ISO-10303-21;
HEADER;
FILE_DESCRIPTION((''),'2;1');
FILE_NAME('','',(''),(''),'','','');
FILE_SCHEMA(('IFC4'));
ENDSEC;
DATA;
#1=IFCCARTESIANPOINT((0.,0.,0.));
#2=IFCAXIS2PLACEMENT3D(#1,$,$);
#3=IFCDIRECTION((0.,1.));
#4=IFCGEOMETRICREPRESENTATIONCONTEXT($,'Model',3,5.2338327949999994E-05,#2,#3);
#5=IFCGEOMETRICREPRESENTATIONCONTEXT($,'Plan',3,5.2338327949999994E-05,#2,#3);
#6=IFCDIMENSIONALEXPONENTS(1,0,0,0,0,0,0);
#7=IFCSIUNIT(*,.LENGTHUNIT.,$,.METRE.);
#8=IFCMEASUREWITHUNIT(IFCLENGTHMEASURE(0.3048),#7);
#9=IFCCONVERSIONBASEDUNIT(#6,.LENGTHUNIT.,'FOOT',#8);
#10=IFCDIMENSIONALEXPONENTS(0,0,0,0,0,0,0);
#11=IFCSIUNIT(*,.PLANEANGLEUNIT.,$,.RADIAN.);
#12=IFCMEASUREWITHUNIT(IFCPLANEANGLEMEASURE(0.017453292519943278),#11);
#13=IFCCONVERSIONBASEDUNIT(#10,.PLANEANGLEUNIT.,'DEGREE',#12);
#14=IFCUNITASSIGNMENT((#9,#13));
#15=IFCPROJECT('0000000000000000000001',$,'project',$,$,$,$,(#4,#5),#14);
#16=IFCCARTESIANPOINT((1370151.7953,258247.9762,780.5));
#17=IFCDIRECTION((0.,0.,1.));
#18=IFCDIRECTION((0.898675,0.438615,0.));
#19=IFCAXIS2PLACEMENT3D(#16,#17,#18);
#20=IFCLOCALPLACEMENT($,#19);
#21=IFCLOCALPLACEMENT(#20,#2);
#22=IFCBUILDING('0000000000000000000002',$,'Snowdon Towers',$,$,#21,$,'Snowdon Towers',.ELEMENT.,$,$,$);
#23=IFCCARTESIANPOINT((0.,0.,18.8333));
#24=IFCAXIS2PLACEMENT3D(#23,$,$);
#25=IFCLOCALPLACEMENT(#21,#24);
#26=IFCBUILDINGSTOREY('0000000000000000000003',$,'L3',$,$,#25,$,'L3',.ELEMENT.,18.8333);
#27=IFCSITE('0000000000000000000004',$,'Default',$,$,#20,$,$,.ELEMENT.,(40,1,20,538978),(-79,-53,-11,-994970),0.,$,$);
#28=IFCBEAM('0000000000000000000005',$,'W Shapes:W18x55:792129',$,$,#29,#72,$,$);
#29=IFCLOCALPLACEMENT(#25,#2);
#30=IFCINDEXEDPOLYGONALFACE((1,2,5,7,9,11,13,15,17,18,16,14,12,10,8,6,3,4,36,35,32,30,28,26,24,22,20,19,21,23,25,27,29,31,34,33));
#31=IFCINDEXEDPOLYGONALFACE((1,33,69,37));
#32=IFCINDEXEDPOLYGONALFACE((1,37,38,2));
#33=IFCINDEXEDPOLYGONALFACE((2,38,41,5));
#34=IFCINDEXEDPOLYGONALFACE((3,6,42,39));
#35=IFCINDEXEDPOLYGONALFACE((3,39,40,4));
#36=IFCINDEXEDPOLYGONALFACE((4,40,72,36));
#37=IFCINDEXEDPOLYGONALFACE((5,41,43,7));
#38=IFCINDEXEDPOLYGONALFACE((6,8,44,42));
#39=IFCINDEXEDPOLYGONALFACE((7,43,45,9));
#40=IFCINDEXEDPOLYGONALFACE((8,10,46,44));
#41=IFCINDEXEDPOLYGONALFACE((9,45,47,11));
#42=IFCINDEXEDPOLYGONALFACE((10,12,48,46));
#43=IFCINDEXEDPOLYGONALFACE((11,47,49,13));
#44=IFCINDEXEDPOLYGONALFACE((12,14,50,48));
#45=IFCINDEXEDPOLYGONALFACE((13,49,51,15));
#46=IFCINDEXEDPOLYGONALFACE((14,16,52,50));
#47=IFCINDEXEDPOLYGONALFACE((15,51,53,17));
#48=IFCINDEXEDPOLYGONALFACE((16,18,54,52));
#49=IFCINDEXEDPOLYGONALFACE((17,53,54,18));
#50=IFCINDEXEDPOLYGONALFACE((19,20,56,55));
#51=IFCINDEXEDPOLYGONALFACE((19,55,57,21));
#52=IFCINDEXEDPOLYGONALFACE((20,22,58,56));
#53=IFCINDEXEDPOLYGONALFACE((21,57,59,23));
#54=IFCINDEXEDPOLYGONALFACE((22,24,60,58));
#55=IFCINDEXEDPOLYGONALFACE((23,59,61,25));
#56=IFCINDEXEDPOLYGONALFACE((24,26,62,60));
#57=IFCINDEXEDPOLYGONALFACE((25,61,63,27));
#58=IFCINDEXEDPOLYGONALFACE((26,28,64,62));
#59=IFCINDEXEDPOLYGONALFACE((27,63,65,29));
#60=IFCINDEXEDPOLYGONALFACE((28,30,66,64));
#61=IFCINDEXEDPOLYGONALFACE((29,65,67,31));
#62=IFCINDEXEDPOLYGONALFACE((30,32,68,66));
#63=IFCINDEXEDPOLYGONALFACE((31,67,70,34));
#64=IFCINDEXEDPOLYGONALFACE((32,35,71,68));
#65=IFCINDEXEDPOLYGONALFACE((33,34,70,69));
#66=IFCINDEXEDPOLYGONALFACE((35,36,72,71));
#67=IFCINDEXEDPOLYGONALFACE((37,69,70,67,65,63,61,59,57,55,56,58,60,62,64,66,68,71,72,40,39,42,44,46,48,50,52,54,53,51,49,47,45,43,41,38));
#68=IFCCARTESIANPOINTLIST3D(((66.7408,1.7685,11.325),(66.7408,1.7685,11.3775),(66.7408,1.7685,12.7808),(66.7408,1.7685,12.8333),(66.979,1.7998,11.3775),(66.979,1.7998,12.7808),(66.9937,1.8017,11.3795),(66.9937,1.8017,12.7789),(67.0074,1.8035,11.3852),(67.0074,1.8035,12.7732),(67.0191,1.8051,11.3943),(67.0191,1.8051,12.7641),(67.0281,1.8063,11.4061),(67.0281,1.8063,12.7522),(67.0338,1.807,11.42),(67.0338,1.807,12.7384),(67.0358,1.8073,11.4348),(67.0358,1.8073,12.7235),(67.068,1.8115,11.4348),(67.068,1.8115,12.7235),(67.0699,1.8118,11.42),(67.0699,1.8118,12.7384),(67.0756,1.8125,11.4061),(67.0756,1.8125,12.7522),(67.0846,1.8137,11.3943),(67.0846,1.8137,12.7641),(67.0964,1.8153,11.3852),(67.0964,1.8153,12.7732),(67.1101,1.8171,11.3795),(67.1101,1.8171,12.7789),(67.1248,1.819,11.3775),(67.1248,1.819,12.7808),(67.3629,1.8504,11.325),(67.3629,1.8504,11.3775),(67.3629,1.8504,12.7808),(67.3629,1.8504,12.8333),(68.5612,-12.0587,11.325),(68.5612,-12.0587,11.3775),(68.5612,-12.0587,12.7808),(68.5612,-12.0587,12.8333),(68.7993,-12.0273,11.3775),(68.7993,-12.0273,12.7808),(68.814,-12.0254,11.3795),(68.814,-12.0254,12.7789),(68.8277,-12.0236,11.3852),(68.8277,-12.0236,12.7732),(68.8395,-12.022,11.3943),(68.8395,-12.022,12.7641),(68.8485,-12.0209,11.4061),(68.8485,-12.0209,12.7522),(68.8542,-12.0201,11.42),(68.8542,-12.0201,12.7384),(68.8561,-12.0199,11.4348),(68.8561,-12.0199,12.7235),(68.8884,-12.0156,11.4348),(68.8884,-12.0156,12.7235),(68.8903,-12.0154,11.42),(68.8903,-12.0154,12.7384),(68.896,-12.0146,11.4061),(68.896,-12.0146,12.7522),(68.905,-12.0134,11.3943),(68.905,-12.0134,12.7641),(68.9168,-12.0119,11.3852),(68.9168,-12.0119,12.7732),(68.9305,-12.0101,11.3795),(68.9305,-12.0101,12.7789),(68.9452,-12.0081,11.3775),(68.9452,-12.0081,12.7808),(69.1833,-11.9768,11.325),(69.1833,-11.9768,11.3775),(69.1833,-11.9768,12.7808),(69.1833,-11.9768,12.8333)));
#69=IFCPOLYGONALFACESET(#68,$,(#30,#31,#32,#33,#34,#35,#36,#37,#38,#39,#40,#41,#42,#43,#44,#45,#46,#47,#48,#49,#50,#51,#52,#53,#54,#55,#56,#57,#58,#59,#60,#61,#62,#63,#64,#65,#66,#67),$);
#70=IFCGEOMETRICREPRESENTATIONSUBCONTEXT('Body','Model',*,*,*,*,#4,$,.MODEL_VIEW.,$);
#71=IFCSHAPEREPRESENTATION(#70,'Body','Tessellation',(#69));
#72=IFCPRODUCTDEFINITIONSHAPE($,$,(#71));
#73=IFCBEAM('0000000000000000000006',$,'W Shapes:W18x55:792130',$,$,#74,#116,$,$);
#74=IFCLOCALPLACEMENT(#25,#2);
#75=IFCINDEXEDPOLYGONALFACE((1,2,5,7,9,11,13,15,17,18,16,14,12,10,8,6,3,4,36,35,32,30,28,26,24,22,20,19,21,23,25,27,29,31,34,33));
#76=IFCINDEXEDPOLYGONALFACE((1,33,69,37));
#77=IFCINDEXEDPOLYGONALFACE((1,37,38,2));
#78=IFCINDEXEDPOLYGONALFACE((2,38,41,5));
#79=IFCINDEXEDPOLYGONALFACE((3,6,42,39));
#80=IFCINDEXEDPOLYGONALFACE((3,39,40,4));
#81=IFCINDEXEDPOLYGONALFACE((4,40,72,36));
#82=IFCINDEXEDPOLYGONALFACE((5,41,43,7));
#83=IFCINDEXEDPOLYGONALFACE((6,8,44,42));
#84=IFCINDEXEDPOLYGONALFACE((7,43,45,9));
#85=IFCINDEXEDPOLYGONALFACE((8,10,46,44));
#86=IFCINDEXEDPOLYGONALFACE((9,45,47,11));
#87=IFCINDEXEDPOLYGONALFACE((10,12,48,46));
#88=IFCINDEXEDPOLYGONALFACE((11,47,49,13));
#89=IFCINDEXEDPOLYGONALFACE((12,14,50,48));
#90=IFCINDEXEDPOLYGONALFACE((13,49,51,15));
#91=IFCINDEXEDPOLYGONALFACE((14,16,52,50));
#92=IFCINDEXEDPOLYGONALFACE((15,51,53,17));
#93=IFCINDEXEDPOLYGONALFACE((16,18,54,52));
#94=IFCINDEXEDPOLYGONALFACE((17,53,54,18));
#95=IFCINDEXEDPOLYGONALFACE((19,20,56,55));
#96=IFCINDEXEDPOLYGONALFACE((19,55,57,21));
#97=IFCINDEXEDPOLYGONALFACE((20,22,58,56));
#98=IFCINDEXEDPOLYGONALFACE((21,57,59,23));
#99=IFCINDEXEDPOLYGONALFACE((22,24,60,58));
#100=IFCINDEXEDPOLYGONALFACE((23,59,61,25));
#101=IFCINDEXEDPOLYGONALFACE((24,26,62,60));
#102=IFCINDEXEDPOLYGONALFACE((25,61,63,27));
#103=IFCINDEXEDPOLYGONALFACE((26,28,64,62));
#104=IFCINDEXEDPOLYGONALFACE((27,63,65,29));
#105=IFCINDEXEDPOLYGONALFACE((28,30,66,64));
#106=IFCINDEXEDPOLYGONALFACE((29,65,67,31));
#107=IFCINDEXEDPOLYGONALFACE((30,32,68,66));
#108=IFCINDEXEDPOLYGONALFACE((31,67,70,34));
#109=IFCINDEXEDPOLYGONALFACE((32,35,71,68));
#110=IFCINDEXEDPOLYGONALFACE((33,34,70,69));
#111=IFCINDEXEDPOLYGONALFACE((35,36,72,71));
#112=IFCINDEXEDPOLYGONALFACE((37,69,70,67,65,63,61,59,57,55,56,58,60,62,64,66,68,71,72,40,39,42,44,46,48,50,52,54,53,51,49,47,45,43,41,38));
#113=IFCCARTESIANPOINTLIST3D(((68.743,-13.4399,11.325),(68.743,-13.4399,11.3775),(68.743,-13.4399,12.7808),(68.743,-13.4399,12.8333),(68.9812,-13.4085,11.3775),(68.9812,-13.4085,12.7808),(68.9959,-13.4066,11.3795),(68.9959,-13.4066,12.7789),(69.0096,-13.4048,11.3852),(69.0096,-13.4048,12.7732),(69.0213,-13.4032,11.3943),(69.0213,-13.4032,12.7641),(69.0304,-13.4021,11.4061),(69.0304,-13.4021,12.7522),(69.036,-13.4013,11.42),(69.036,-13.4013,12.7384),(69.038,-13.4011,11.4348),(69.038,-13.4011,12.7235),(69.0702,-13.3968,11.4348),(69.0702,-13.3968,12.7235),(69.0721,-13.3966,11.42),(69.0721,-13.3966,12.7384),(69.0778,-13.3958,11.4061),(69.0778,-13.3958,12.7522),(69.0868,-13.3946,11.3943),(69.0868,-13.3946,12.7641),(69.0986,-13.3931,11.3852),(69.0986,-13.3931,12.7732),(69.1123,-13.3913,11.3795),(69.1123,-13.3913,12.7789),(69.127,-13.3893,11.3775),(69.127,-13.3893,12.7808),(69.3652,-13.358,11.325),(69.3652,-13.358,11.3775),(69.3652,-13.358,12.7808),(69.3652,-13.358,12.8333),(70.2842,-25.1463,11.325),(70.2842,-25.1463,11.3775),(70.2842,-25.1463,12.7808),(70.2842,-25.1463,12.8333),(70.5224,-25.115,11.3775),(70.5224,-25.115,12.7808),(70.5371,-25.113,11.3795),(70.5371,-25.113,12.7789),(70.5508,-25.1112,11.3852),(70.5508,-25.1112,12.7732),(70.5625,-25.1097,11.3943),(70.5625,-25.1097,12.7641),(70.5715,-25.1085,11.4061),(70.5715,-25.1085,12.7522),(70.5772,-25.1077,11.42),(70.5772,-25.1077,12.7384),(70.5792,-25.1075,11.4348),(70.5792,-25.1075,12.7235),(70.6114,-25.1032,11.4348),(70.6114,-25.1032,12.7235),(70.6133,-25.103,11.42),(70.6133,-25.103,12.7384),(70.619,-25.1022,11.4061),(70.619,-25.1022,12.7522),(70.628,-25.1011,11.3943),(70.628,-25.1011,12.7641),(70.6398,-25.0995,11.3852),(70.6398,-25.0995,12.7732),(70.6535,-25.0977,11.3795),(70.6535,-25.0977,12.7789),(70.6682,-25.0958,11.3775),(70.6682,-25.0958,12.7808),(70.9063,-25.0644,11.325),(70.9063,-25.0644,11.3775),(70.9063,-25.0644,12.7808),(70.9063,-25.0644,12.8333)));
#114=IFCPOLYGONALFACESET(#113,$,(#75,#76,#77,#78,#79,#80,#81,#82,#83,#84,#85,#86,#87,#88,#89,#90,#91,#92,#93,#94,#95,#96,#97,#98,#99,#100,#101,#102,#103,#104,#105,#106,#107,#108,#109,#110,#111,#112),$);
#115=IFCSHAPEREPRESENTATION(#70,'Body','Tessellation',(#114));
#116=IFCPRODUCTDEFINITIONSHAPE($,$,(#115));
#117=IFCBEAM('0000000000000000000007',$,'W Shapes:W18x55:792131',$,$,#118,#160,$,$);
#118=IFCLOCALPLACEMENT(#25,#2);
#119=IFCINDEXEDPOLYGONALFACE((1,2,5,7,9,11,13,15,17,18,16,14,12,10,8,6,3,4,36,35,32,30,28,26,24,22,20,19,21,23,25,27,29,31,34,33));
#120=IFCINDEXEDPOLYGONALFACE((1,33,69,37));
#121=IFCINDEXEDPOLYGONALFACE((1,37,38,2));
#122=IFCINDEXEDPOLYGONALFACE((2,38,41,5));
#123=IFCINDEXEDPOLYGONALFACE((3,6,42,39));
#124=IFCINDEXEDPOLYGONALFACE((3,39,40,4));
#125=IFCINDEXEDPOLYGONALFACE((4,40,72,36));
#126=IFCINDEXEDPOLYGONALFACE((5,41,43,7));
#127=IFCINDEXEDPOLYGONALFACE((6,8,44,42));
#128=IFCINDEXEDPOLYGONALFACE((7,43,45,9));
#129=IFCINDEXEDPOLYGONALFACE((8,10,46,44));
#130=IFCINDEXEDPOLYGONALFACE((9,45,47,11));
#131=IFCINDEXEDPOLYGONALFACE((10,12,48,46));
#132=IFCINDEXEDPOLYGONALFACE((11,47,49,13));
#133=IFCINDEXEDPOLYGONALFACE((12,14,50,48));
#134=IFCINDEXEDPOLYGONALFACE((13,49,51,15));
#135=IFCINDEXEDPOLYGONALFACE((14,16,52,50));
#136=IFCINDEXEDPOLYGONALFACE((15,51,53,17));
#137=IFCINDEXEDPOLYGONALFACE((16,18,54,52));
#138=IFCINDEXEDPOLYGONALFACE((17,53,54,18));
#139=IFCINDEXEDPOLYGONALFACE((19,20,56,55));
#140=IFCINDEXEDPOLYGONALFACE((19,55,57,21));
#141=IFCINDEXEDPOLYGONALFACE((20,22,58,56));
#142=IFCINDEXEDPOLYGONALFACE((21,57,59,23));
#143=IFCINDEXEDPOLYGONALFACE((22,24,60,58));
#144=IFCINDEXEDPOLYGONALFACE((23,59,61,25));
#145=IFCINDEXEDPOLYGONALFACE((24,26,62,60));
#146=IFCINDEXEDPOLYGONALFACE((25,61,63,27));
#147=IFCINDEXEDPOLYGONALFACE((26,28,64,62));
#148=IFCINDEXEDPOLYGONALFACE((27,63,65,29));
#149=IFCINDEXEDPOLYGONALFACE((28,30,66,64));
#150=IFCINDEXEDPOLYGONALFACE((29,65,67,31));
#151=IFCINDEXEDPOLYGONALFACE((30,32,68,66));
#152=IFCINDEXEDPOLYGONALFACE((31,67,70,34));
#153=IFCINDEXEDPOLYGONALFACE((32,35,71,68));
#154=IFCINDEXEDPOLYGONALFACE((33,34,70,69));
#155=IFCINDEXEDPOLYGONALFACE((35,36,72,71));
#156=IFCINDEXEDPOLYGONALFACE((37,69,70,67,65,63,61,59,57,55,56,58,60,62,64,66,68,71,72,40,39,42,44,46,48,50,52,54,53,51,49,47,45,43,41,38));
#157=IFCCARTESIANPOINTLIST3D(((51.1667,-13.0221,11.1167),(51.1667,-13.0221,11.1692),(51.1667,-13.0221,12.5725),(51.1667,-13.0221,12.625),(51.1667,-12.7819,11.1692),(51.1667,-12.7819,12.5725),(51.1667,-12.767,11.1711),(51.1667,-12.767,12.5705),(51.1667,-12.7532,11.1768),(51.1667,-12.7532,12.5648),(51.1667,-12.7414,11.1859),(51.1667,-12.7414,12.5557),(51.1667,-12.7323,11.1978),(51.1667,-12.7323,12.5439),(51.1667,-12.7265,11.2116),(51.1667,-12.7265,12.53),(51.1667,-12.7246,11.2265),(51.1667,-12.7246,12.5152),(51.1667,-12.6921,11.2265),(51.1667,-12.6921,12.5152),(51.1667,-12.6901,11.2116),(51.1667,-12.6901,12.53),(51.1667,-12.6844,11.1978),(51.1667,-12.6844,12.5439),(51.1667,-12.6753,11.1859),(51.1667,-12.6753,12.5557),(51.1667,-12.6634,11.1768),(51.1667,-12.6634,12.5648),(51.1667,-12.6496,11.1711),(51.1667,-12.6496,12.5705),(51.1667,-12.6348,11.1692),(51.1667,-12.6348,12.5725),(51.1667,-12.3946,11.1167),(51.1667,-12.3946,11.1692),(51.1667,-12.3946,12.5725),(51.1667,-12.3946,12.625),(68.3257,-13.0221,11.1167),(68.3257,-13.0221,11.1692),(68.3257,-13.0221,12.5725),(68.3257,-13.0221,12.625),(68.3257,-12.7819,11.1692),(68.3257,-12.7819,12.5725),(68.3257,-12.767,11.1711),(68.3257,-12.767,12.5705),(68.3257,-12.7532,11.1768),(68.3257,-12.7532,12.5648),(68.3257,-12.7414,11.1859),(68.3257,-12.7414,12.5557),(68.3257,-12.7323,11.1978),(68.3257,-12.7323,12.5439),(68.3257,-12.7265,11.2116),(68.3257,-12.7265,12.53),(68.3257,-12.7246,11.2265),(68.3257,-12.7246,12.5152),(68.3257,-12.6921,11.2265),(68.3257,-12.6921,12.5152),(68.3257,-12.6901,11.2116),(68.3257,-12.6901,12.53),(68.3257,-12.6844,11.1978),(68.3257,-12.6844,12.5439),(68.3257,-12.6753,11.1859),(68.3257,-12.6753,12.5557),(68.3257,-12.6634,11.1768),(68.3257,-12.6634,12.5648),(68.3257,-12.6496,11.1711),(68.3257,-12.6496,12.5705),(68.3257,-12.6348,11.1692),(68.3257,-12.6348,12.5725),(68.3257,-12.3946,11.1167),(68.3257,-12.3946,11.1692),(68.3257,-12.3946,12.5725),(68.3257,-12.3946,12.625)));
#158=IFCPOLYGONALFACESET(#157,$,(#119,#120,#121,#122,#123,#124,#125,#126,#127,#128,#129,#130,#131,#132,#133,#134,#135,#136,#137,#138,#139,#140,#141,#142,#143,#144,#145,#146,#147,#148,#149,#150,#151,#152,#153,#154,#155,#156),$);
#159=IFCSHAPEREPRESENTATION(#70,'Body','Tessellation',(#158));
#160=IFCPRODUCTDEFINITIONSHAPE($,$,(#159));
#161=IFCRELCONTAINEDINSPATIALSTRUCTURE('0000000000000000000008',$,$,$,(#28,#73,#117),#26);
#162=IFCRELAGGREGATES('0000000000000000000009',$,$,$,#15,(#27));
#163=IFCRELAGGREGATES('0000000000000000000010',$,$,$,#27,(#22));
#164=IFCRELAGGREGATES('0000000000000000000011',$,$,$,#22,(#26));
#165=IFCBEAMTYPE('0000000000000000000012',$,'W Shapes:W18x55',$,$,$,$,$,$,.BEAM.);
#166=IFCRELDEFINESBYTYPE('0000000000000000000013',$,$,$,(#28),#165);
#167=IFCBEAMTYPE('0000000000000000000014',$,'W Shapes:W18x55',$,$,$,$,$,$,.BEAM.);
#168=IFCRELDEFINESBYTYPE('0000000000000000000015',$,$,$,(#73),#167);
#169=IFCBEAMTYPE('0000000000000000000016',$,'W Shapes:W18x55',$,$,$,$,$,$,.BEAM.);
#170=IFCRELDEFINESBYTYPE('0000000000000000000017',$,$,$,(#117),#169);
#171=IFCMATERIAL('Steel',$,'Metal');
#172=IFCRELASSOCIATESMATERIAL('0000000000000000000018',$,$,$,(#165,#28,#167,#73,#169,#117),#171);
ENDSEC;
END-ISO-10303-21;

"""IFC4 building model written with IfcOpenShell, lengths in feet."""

from ifc_helpers import new_model, entity, si_unit, converted_unit, direction, frame, origin, place, context, subcontext, project, spatial, line, arc, indexed_curve, outline, extrude, source, transform, mapped, material, type_object, type_shapes, element, save


model = new_model("IFC4")

# Units and contexts
model_context = context("Model", 3, precision=5.2338327949999994e-05, world=origin(), true_north=direction((0.0, 1.0)))
plan_context = context("Plan", 3, precision=5.2338327949999994e-05, world=origin(), true_north=direction((0.0, 1.0)))
body_context = subcontext(model_context, "Body", "Model", "MODEL_VIEW")
ifc_project = project(units=[converted_unit("LENGTHUNIT", "FOOT", entity("IfcLengthMeasure", 0.3048), si_unit("LENGTHUNIT", "METRE"), dimensions=[1, 0, 0, 0, 0, 0, 0]), converted_unit("PLANEANGLEUNIT", "DEGREE", entity("IfcPlaneAngleMeasure", 0.017453292519943278), si_unit("PLANEANGLEUNIT", "RADIAN"), dimensions=[0, 0, 0, 0, 0, 0, 0])], contexts=[model_context, plan_context])

# Site, building, storey
site_placement = place(None, frame((1370151.7953, 258247.9762, 780.5), z_axis=(0.0, 0.0, 1.0), x_axis=(0.898675, 0.438615, 0.0)))
site = spatial("IfcSite", under=ifc_project, at=site_placement, Name="Default", CompositionType="ELEMENT", RefLatitude=(40, 1, 20, 538978), RefLongitude=(-79, -53, -11, -994970), RefElevation=0.0)
building_placement = place(site_placement, origin())
building = spatial("IfcBuilding", under=site, at=building_placement, Name="Snowdon Towers", LongName="Snowdon Towers", CompositionType="ELEMENT")
storey_placement = place(building_placement, frame((0.0, 0.0, 18.8333)))
storey = spatial("IfcBuildingStorey", under=building, at=storey_placement, Name="L3", LongName="L3", CompositionType="ELEMENT", Elevation=18.8333)

# Beams
ifc_material_1 = material(Name="Steel", Category="Metal")
beam_type_1 = type_object("IfcBeamType", Name="W Shapes:W18x55", PredefinedType="BEAM", material=ifc_material_1)
shared_shape_1 = source(origin(), body_context, "Body", "SweptSolid", [
    extrude(outline(indexed_curve([(-0.7542, -0.3138), (-0.7017, -0.3138), (-0.7017, -0.0735), (-0.6849, -0.033), (-0.6444, -0.0162), (0.6444, -0.0162), (0.6849, -0.033), (0.7017, -0.0735), (0.7017, -0.3138), (0.7542, -0.3138), (0.7542, 0.3138), (0.7017, 0.3138), (0.7017, 0.0735), (0.6849, 0.033), (0.6444, 0.0163), (-0.6444, 0.0163), (-0.6849, 0.033), (-0.7017, 0.0735), (-0.7017, 0.3137), (-0.7542, 0.3137)], segments=[line(1, 2, 3), arc(3, 4, 5), line(5, 6), arc(6, 7, 8), line(8, 9, 10, 11, 12, 13), arc(13, 14, 15), line(15, 16), arc(16, 17, 18), line(18, 19, 20, 1)], self_intersect=False)), frame((-7.05, 0.0, 0.0), z_axis=(1.0, 0.0, 0.0), x_axis=(0.0, 0.0, -1.0)), (0.0, 0.0, 1.0), 13.9465),
])
type_shapes(beam_type_1, [shared_shape_1])
beam_1_placement = place(storey_placement, frame((67.9721, -5.1803, 12.0792), z_axis=(0.0, 0.0, 1.0), x_axis=(0.130526, -0.991445, 0.0)))
element("IfcBeam", 1, at=beam_1_placement, inside=storey, type_object=beam_type_1, material=ifc_material_1, Name="W Shapes:W18x55:792129", context=body_context, shape_type="MappedRepresentation", body=[
    mapped(shared_shape_1, transform((0.0, 0.0, 0.0), scale=1.0)),
])
beam_type_2 = type_object("IfcBeamType", Name="W Shapes:W18x55", PredefinedType="BEAM", material=ifc_material_1)
shared_shape_2 = source(origin(), body_context, "Body", "SweptSolid", [
    extrude(outline(indexed_curve([(-0.7542, -0.3138), (-0.7017, -0.3138), (-0.7017, -0.0735), (-0.6849, -0.033), (-0.6444, -0.0162), (0.6444, -0.0162), (0.6849, -0.033), (0.7017, -0.0735), (0.7017, -0.3138), (0.7542, -0.3138), (0.7542, 0.3138), (0.7017, 0.3138), (0.7017, 0.0735), (0.6849, 0.033), (0.6444, 0.0163), (-0.6444, 0.0163), (-0.6849, 0.033), (-0.7017, 0.0735), (-0.7017, 0.3137), (-0.7542, 0.3137)], segments=[line(1, 2, 3), arc(3, 4, 5), line(5, 6), arc(6, 7, 8), line(8, 9, 10, 11, 12, 13), arc(13, 14, 15), line(15, 16), arc(16, 17, 18), line(18, 19, 20, 1)], self_intersect=False)), frame((-5.9188, 0.0, 0.0), z_axis=(1.0, 0.0, 0.0), x_axis=(0.0, 0.0, -1.0)), (0.0, 0.0, 1.0), 11.8075),
])
type_shapes(beam_type_2, [shared_shape_2])
beam_2_placement = place(storey_placement, frame((69.8266, -19.2671, 12.0792), z_axis=(0.0, 0.0, 1.0), x_axis=(0.130526, -0.991445, 0.0)))
element("IfcBeam", 2, at=beam_2_placement, inside=storey, type_object=beam_type_2, material=ifc_material_1, Name="W Shapes:W18x55:792130", context=body_context, shape_type="MappedRepresentation", body=[
    mapped(shared_shape_2, transform((0.0, 0.0, 0.0), scale=1.0)),
])
beam_type_3 = type_object("IfcBeamType", Name="W Shapes:W18x55", PredefinedType="BEAM", material=ifc_material_1)
shared_shape_3 = source(origin(), body_context, "Body", "SweptSolid", [
    extrude(outline(indexed_curve([(-0.7542, -0.3138), (-0.7017, -0.3138), (-0.7017, -0.0735), (-0.6849, -0.033), (-0.6444, -0.0162), (0.6444, -0.0162), (0.6849, -0.033), (0.7017, -0.0735), (0.7017, -0.3138), (0.7542, -0.3138), (0.7542, 0.3138), (0.7017, 0.3138), (0.7017, 0.0735), (0.6849, 0.033), (0.6444, 0.0163), (-0.6444, 0.0163), (-0.6849, 0.033), (-0.7017, 0.0735), (-0.7017, 0.3137), (-0.7542, 0.3137)], segments=[line(1, 2, 3), arc(3, 4, 5), line(5, 6), arc(6, 7, 8), line(8, 9, 10, 11, 12, 13), arc(13, 14, 15), line(15, 16), arc(16, 17, 18), line(18, 19, 20, 1)], self_intersect=False)), frame((-8.9216, 0.0, 0.0), z_axis=(1.0, 0.0, 0.0), x_axis=(0.0, 0.0, -1.0)), (0.0, 0.0, 1.0), 17.159),
])
type_shapes(beam_type_3, [shared_shape_3])
beam_3_placement = place(storey_placement, frame((60.0883, -12.7083, 11.8708)))
element("IfcBeam", 3, at=beam_3_placement, inside=storey, type_object=beam_type_3, material=ifc_material_1, Name="W Shapes:W18x55:792131", context=body_context, shape_type="MappedRepresentation", body=[
    mapped(shared_shape_3, transform((0.0, 0.0, 0.0), scale=1.0)),
])

save(model, "model.ifc")
